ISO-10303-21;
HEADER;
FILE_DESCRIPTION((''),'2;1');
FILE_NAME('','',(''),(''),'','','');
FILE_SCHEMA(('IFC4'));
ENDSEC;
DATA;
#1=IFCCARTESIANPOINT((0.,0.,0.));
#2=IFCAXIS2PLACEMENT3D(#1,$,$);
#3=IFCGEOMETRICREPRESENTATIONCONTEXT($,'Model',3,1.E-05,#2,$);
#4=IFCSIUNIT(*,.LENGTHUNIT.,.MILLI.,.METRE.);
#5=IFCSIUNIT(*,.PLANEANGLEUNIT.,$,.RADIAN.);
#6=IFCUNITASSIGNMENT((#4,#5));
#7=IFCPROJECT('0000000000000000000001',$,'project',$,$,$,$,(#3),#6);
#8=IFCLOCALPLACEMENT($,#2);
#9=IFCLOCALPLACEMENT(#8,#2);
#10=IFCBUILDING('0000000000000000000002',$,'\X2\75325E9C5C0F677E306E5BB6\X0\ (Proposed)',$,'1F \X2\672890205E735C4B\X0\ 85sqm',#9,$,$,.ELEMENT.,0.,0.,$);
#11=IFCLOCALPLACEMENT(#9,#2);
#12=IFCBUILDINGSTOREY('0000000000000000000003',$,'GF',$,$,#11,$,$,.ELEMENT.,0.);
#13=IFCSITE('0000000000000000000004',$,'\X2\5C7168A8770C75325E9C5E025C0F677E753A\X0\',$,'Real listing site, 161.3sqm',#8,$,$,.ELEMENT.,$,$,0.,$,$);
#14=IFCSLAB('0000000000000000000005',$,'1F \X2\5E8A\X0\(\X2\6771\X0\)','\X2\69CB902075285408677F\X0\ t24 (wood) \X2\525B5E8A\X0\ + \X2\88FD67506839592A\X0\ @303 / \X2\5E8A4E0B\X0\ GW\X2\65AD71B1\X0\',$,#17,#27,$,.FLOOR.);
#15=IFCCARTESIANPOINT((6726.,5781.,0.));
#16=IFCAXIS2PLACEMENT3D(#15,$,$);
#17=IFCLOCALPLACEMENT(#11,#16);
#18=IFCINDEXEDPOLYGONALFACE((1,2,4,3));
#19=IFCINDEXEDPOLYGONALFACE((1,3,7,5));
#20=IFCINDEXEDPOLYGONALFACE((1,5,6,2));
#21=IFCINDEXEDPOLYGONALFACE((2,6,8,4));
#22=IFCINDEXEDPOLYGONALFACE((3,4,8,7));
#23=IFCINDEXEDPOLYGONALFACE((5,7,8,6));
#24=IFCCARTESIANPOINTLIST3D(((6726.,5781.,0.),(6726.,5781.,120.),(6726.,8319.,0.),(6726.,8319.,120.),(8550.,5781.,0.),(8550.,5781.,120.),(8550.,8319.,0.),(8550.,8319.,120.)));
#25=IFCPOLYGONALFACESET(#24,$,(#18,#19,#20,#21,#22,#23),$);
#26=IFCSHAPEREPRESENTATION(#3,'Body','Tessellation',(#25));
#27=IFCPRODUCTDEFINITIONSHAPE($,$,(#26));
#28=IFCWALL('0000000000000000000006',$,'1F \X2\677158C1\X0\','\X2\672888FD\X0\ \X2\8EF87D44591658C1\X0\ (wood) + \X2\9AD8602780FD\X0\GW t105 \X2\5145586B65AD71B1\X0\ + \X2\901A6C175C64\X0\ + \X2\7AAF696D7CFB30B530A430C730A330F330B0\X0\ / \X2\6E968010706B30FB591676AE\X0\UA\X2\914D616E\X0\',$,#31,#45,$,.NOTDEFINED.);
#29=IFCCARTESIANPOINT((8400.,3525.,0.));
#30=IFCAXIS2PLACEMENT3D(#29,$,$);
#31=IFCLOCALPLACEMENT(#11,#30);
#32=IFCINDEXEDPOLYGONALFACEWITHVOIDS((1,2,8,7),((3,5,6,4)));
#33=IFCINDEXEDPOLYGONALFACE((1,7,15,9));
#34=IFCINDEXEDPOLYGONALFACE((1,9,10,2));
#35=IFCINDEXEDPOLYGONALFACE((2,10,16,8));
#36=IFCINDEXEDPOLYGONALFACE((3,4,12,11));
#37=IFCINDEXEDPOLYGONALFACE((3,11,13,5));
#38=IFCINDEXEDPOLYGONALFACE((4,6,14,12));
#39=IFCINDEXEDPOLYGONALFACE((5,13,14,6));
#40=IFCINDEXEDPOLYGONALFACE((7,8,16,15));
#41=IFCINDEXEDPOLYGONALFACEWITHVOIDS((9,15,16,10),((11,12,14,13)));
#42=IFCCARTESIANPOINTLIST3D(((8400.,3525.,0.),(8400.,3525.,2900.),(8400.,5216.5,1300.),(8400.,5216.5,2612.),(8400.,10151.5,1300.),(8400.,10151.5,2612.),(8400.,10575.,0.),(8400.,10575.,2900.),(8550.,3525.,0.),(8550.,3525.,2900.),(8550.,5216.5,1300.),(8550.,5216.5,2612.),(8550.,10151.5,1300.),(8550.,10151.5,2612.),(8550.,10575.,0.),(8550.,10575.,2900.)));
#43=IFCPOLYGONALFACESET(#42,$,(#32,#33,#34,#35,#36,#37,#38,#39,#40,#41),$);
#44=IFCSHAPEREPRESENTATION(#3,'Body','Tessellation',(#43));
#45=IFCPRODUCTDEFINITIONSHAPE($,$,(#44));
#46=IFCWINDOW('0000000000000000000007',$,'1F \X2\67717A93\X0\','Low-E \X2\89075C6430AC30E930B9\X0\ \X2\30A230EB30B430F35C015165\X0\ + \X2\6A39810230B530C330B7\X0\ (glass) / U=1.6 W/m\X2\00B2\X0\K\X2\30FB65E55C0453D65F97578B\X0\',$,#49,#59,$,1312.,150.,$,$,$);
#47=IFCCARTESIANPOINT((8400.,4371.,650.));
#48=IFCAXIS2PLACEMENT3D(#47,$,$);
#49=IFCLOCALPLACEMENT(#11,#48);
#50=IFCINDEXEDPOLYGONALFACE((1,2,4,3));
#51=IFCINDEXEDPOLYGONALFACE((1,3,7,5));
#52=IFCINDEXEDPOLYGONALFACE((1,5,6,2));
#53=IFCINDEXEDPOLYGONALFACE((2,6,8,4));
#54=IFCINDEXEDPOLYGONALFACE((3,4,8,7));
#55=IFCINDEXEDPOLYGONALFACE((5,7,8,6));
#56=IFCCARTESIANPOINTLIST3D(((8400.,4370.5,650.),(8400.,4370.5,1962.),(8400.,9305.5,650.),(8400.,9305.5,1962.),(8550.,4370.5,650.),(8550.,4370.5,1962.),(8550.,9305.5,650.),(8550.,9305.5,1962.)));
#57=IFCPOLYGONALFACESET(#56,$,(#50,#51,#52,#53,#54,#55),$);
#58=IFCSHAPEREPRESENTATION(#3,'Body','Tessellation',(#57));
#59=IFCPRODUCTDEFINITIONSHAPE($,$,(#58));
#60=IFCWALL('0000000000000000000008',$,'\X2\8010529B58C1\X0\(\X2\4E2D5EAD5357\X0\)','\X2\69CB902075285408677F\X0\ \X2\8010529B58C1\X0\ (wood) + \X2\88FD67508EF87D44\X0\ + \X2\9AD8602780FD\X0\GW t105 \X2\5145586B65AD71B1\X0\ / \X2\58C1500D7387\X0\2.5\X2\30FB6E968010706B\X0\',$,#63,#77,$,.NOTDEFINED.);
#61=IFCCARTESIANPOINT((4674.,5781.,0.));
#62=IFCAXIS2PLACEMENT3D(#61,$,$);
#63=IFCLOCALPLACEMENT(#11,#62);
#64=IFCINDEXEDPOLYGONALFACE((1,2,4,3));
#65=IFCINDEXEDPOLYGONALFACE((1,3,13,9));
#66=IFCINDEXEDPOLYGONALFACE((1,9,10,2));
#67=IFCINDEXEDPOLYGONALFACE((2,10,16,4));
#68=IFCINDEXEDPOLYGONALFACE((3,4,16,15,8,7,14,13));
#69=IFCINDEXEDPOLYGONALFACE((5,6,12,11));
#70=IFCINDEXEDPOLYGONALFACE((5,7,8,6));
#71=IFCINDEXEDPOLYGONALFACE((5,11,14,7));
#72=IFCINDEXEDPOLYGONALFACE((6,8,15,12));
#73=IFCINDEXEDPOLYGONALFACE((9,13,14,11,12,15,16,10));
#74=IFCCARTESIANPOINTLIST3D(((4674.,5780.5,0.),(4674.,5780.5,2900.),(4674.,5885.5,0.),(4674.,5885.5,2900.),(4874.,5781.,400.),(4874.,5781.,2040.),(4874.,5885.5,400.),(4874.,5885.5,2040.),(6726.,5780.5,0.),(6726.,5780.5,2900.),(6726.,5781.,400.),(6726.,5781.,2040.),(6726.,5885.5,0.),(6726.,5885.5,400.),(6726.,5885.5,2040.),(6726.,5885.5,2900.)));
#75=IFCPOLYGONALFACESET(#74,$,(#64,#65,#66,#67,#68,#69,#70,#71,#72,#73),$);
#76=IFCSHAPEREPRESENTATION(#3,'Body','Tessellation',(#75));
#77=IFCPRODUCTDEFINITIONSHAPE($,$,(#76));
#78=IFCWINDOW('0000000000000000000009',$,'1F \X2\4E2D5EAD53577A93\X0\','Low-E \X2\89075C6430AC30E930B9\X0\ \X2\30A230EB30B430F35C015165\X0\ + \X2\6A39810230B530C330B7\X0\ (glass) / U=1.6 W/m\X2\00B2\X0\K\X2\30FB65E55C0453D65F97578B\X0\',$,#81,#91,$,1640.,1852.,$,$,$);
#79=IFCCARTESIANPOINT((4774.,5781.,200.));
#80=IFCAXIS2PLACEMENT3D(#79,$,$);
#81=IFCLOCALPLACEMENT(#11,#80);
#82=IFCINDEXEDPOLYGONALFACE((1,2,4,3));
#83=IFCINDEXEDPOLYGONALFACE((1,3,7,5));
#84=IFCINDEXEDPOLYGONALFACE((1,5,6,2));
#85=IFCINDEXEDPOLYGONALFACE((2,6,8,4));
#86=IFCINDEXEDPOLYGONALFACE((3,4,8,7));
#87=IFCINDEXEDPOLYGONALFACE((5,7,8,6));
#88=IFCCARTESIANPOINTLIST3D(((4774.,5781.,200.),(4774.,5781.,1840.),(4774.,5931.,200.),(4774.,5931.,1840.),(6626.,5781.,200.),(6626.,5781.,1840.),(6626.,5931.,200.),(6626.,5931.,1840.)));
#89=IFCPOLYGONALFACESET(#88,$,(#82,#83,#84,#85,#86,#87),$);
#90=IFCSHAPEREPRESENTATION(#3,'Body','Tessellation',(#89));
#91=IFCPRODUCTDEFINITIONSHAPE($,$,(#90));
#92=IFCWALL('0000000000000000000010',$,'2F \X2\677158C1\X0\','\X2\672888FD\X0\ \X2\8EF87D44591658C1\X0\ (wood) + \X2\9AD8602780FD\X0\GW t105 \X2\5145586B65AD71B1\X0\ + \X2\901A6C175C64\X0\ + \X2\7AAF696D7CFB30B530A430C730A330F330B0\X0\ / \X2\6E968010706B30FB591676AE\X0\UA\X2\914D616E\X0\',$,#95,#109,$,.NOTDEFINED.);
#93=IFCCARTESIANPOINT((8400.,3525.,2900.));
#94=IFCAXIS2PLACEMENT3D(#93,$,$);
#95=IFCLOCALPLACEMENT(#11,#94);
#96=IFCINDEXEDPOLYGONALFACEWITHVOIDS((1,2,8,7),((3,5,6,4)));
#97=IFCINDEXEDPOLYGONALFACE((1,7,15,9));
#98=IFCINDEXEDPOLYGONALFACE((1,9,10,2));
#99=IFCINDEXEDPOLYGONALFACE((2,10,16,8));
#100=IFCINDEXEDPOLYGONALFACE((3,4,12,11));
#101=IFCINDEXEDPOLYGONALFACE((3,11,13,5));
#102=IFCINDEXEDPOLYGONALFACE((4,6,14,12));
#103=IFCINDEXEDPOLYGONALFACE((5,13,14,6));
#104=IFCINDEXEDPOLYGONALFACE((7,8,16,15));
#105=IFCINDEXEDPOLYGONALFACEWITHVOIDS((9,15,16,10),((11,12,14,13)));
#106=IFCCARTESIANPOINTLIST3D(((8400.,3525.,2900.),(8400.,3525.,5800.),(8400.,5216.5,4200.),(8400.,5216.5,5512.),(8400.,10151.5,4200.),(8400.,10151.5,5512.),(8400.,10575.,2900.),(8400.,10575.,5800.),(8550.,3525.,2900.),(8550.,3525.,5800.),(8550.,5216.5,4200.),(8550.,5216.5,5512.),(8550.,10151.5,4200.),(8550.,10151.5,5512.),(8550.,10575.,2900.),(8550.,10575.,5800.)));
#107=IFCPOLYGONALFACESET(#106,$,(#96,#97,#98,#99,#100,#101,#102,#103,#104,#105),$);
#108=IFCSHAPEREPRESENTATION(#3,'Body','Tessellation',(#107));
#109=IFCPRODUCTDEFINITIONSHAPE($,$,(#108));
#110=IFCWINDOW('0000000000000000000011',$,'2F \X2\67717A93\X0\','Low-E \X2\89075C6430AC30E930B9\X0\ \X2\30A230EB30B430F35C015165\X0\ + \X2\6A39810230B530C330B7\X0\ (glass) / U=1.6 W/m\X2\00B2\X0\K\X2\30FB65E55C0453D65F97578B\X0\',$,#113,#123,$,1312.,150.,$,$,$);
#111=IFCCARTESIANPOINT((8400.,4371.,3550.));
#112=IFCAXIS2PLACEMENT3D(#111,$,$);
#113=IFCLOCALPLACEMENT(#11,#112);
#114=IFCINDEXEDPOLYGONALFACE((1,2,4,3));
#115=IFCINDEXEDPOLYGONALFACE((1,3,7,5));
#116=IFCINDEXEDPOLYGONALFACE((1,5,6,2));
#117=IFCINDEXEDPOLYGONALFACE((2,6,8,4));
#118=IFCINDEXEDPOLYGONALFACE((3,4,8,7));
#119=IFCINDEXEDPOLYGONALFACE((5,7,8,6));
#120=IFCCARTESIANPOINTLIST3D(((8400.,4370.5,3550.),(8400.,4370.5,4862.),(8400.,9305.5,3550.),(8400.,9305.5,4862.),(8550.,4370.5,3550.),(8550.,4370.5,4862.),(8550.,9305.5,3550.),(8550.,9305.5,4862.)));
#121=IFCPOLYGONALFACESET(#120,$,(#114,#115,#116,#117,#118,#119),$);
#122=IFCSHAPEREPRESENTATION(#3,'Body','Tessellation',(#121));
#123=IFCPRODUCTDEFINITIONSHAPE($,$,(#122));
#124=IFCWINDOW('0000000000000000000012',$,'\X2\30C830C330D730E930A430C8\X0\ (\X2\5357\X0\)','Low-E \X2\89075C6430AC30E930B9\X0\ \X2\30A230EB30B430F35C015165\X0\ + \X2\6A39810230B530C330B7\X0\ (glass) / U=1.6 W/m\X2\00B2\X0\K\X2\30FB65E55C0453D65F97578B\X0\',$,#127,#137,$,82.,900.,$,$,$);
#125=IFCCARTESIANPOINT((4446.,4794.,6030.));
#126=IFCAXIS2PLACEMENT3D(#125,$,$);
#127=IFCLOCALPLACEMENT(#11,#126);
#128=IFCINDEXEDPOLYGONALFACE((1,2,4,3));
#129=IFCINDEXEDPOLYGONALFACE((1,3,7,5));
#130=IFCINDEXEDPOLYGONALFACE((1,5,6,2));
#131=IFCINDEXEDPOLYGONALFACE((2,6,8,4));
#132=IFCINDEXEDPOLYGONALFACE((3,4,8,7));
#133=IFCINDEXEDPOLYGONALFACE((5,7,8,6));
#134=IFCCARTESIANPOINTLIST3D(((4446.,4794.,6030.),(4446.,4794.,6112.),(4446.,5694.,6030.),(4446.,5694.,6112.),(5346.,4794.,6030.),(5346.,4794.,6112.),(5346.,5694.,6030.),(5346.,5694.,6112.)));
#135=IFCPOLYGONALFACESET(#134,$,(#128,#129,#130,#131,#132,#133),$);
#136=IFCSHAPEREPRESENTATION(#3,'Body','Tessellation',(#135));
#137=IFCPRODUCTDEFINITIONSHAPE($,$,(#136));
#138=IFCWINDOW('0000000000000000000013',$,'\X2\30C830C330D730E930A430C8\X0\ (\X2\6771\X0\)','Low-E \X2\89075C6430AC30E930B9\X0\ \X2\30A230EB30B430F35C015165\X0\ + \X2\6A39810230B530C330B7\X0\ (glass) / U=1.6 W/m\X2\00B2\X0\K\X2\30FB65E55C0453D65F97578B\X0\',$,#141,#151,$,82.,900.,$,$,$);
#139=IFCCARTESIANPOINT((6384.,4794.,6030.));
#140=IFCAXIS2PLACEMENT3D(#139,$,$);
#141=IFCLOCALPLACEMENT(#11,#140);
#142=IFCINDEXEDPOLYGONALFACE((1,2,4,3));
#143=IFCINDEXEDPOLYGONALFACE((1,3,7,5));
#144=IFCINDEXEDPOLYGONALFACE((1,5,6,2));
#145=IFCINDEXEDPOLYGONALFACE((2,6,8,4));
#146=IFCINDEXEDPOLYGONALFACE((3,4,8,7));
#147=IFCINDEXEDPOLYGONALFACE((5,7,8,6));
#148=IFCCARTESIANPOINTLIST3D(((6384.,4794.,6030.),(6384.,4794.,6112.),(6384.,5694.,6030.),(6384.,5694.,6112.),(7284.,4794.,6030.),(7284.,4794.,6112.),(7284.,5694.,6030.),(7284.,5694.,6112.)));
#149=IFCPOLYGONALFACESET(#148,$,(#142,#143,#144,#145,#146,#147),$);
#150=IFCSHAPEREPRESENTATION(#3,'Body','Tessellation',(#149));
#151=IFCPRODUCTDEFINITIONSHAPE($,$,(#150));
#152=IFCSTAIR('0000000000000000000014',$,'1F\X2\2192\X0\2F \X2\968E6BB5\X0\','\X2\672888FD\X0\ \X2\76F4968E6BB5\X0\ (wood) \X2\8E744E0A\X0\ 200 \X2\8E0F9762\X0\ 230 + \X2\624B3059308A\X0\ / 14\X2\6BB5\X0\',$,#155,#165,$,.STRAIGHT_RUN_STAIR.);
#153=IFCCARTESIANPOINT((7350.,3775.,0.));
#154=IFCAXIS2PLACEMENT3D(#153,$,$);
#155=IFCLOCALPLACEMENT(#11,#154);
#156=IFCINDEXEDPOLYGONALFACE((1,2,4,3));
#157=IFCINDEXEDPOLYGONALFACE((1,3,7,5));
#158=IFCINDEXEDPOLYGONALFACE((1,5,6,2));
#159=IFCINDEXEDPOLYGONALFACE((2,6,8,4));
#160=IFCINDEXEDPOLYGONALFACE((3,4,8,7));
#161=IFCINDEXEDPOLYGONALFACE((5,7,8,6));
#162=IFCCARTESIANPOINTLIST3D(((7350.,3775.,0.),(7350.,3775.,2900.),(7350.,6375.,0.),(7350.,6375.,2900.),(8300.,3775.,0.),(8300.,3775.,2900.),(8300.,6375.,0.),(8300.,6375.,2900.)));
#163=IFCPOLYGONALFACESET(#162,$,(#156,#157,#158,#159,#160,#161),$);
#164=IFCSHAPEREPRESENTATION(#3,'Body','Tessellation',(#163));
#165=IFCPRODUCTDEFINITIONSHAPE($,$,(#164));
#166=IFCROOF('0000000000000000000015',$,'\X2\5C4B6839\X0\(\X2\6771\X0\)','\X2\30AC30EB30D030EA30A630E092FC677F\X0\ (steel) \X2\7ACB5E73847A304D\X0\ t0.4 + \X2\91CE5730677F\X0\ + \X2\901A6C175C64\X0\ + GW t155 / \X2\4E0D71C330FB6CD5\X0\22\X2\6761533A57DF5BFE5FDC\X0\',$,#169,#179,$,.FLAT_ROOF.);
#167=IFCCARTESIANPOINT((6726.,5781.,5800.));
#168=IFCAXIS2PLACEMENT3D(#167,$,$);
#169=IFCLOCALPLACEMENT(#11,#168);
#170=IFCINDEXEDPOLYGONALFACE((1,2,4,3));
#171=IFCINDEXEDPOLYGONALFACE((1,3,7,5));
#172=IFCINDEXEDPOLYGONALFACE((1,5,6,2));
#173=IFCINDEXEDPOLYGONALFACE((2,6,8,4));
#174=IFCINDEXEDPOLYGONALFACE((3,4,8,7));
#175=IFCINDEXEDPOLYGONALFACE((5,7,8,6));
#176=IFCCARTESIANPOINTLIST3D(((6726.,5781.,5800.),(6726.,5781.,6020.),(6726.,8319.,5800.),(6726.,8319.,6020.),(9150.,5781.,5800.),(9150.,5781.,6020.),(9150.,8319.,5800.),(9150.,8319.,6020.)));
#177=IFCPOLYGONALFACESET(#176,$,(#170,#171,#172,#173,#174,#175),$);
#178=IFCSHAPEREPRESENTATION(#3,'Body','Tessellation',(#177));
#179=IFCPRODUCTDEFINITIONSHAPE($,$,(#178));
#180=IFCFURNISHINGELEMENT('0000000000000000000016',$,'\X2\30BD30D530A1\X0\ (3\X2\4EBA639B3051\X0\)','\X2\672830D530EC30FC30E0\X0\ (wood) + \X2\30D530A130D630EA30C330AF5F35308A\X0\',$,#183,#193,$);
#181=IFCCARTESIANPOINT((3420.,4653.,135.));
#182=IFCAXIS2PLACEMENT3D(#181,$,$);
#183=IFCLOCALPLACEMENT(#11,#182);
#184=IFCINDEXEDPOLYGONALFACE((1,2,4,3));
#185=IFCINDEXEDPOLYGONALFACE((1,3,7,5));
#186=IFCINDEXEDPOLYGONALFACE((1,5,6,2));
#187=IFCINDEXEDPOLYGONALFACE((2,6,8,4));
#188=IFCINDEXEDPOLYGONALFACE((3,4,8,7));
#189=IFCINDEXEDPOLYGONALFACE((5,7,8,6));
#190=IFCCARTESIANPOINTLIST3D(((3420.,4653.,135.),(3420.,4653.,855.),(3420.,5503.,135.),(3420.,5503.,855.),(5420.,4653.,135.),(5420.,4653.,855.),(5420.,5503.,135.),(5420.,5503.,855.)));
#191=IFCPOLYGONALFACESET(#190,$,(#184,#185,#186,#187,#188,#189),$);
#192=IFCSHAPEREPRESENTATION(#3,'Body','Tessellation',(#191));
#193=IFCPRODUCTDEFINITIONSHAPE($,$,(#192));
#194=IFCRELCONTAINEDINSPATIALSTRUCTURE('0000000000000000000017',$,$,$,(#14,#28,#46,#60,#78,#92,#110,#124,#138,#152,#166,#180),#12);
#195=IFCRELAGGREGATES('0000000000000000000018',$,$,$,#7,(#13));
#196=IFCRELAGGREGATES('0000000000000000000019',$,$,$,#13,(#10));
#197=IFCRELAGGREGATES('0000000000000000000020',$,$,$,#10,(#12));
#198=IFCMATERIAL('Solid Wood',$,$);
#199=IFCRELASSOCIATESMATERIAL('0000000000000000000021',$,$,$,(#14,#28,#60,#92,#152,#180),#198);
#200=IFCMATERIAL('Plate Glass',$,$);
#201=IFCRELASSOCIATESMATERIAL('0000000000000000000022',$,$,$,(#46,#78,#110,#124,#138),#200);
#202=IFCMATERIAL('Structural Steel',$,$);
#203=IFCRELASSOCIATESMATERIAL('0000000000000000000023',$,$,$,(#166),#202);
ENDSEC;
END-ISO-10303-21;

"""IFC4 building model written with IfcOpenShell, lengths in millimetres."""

from ifc_helpers import new_model, si_unit, frame, frame_2d, origin, place, context, project, spatial, rectangle, extrude, material, element, fill, save


model = new_model("IFC4")

# Units and contexts
model_context = context("Model", 3, precision=1e-05, world=origin())
ifc_project = project(units=[si_unit("LENGTHUNIT", "METRE", prefix="MILLI"), si_unit("PLANEANGLEUNIT", "RADIAN")], contexts=[model_context])

# Site, building, storey
site_placement = place(None, origin())
site = spatial("IfcSite", under=ifc_project, at=site_placement, Name="山梨県甲府市小松町", ObjectType="Real listing site, 161.3sqm", CompositionType="ELEMENT", RefElevation=0.0)
building_placement = place(site_placement, origin())
building = spatial("IfcBuilding", under=site, at=building_placement, Name="甲府小松の家 (Proposed)", ObjectType="1F 木造平屋 85sqm", CompositionType="ELEMENT", ElevationOfRefHeight=0.0, ElevationOfTerrain=0.0)
storey_placement = place(building_placement, origin())
storey = spatial("IfcBuildingStorey", under=building, at=storey_placement, Name="GF", CompositionType="ELEMENT", Elevation=0.0)

# Slab
ifc_material_1 = material(Name="Solid Wood")
slab_placement = place(storey_placement, frame((6726.0, 5781.0, 0.0)))
element("IfcSlab", 1, at=slab_placement, inside=storey, material=ifc_material_1, Name="1F 床(東)", Description="構造用合板 t24 (wood) 剛床 + 製材根太 @303 / 床下 GW断熱", PredefinedType="FLOOR", context=model_context, shape_type="SweptSolid", body=[
    extrude(rectangle(XDim=1824.0, YDim=2538.0, at=frame_2d((912.0, 1269.0))), frame((6726.0, 5781.0, 0.0)), (0.0, 0.0, 1.0), 120.0),
])

# Walls, openings, windows
wall_1_placement = place(storey_placement, frame((8400.0, 3525.0, 0.0)))
wall_1 = element("IfcWall", 2, at=wall_1_placement, inside=storey, material=ifc_material_1, Name="1F 東壁", Description="木製 軸組外壁 (wood) + 高性能GW t105 充填断熱 + 通気層 + 窯業系サイディング / 準耐火・外皮UA配慮", PredefinedType="NOTDEFINED", context=model_context, shape_type="SweptSolid", body=[
    extrude(rectangle(XDim=150.0, YDim=7050.0, at=frame_2d((75.0, 3525.0))), frame((8400.0, 3525.0, 0.0)), (0.0, 0.0, 1.0), 2900.0),
])
opening_1_placement = place(storey_placement, frame((8400.0, 4371.0, 650.0)))
opening_1 = element("IfcOpeningElement", 3, at=opening_1_placement, cuts=wall_1, PredefinedType="NOTDEFINED", context=model_context, shape_type="SweptSolid", body=[
    extrude(rectangle(XDim=150.0, YDim=4935.0, at=frame_2d((75.0, 2467.0))), frame((8400.0, 4371.0, 650.0)), (0.0, 0.0, 1.0), 1312.0),
])
ifc_material_2 = material(Name="Plate Glass")
window_1_placement = place(storey_placement, frame((8400.0, 4371.0, 650.0)))
window_1 = element("IfcWindow", 4, at=window_1_placement, inside=storey, material=ifc_material_2, Name="1F 東窓", Description="Low-E 複層ガラス アルゴン封入 + 樹脂サッシ (glass) / U=1.6 W/m²K・日射取得型", OverallHeight=1312.0, OverallWidth=150.0, context=model_context, shape_type="SweptSolid", body=[
    extrude(rectangle(XDim=150.0, YDim=4935.0, at=frame_2d((75.0, 2467.0))), frame((8400.0, 4371.0, 650.0)), (0.0, 0.0, 1.0), 1312.0),
])
fill(opening_1, window_1)
wall_2_placement = place(storey_placement, frame((4674.0, 5781.0, 0.0)))
wall_2 = element("IfcWall", 5, at=wall_2_placement, inside=storey, material=ifc_material_1, Name="耐力壁(中庭南)", Description="構造用合板 耐力壁 (wood) + 製材軸組 + 高性能GW t105 充填断熱 / 壁倍率2.5・準耐火", PredefinedType="NOTDEFINED", context=model_context, shape_type="SweptSolid", body=[
    extrude(rectangle(XDim=2052.0, YDim=105.0, at=frame_2d((1026.0, 52.0))), frame((4674.0, 5781.0, 0.0)), (0.0, 0.0, 1.0), 2900.0),
])
opening_2_placement = place(storey_placement, frame((4774.0, 5781.0, 200.0)))
opening_2 = element("IfcOpeningElement", 6, at=opening_2_placement, cuts=wall_2, PredefinedType="NOTDEFINED", context=model_context, shape_type="SweptSolid", body=[
    extrude(rectangle(XDim=1852.0, YDim=150.0, at=frame_2d((926.0, 75.0))), frame((4774.0, 5781.0, 200.0)), (0.0, 0.0, 1.0), 1640.0),
])
window_2_placement = place(storey_placement, frame((4774.0, 5781.0, 200.0)))
window_2 = element("IfcWindow", 7, at=window_2_placement, inside=storey, material=ifc_material_2, Name="1F 中庭南窓", Description="Low-E 複層ガラス アルゴン封入 + 樹脂サッシ (glass) / U=1.6 W/m²K・日射取得型", OverallHeight=1640.0, OverallWidth=1852.0, context=model_context, shape_type="SweptSolid", body=[
    extrude(rectangle(XDim=1852.0, YDim=150.0, at=frame_2d((926.0, 75.0))), frame((4774.0, 5781.0, 200.0)), (0.0, 0.0, 1.0), 1640.0),
])
fill(opening_2, window_2)

# Wall, opening, window
wall_3_placement = place(storey_placement, frame((8400.0, 3525.0, 2900.0)))
wall_3 = element("IfcWall", 8, at=wall_3_placement, inside=storey, material=ifc_material_1, Name="2F 東壁", Description="木製 軸組外壁 (wood) + 高性能GW t105 充填断熱 + 通気層 + 窯業系サイディング / 準耐火・外皮UA配慮", PredefinedType="NOTDEFINED", context=model_context, shape_type="SweptSolid", body=[
    extrude(rectangle(XDim=150.0, YDim=7050.0, at=frame_2d((75.0, 3525.0))), frame((8400.0, 3525.0, 2900.0)), (0.0, 0.0, 1.0), 2900.0),
])
opening_3_placement = place(storey_placement, frame((8400.0, 4371.0, 3550.0)))
opening_3 = element("IfcOpeningElement", 9, at=opening_3_placement, cuts=wall_3, PredefinedType="NOTDEFINED", context=model_context, shape_type="SweptSolid", body=[
    extrude(rectangle(XDim=150.0, YDim=4935.0, at=frame_2d((75.0, 2467.0))), frame((8400.0, 4371.0, 3550.0)), (0.0, 0.0, 1.0), 1312.0),
])
window_3_placement = place(storey_placement, frame((8400.0, 4371.0, 3550.0)))
window_3 = element("IfcWindow", 10, at=window_3_placement, inside=storey, material=ifc_material_2, Name="2F 東窓", Description="Low-E 複層ガラス アルゴン封入 + 樹脂サッシ (glass) / U=1.6 W/m²K・日射取得型", OverallHeight=1312.0, OverallWidth=150.0, context=model_context, shape_type="SweptSolid", body=[
    extrude(rectangle(XDim=150.0, YDim=4935.0, at=frame_2d((75.0, 2467.0))), frame((8400.0, 4371.0, 3550.0)), (0.0, 0.0, 1.0), 1312.0),
])
fill(opening_3, window_3)

# Windows
window_4_placement = place(storey_placement, frame((4446.0, 4794.0, 6030.0)))
element("IfcWindow", 11, at=window_4_placement, inside=storey, material=ifc_material_2, Name="トップライト (南)", Description="Low-E 複層ガラス アルゴン封入 + 樹脂サッシ (glass) / U=1.6 W/m²K・日射取得型", OverallHeight=82.0, OverallWidth=900.0, context=model_context, shape_type="SweptSolid", body=[
    extrude(rectangle(XDim=900.0, YDim=900.0, at=frame_2d((450.0, 450.0))), frame((4446.0, 4794.0, 6030.0)), (0.0, 0.0, 1.0), 82.0),
])
window_5_placement = place(storey_placement, frame((6384.0, 4794.0, 6030.0)))
element("IfcWindow", 12, at=window_5_placement, inside=storey, material=ifc_material_2, Name="トップライト (東)", Description="Low-E 複層ガラス アルゴン封入 + 樹脂サッシ (glass) / U=1.6 W/m²K・日射取得型", OverallHeight=82.0, OverallWidth=900.0, context=model_context, shape_type="SweptSolid", body=[
    extrude(rectangle(XDim=900.0, YDim=900.0, at=frame_2d((450.0, 450.0))), frame((6384.0, 4794.0, 6030.0)), (0.0, 0.0, 1.0), 82.0),
])

# Stair
stair_placement = place(storey_placement, frame((7350.0, 3775.0, 0.0)))
element("IfcStair", 13, at=stair_placement, inside=storey, material=ifc_material_1, Name="1F→2F 階段", Description="木製 直階段 (wood) 蹴上 200 踏面 230 + 手すり / 14段", PredefinedType="STRAIGHT_RUN_STAIR", context=model_context, shape_type="SweptSolid", body=[
    extrude(rectangle(XDim=950.0, YDim=2600.0, at=frame_2d((475.0, 1300.0))), frame((7350.0, 3775.0, 0.0)), (0.0, 0.0, 1.0), 2900.0),
])

# Roof
ifc_material_3 = material(Name="Structural Steel")
roof_placement = place(storey_placement, frame((6726.0, 5781.0, 5800.0)))
element("IfcRoof", 14, at=roof_placement, inside=storey, material=ifc_material_3, Name="屋根(東)", Description="ガルバリウム鋼板 (steel) 立平葺き t0.4 + 野地板 + 通気層 + GW t155 / 不燃・法22条区域対応", PredefinedType="FLAT_ROOF", context=model_context, shape_type="SweptSolid", body=[
    extrude(rectangle(XDim=2424.0, YDim=2538.0, at=frame_2d((1212.0, 1269.0))), frame((6726.0, 5781.0, 5800.0)), (0.0, 0.0, 1.0), 220.0),
])

# Furnishing element
furnishing_1_placement = place(storey_placement, frame((3420.0, 4653.0, 135.0)))
element("IfcFurnishingElement", 15, at=furnishing_1_placement, inside=storey, material=ifc_material_1, Name="ソファ (3人掛け)", Description="木フレーム (wood) + ファブリック張り", context=model_context, shape_type="SweptSolid", body=[
    extrude(rectangle(XDim=2000.0, YDim=850.0, at=frame_2d((1000.0, 425.0))), frame((3420.0, 4653.0, 135.0)), (0.0, 0.0, 1.0), 720.0),
])

save(model, "model.ifc")
